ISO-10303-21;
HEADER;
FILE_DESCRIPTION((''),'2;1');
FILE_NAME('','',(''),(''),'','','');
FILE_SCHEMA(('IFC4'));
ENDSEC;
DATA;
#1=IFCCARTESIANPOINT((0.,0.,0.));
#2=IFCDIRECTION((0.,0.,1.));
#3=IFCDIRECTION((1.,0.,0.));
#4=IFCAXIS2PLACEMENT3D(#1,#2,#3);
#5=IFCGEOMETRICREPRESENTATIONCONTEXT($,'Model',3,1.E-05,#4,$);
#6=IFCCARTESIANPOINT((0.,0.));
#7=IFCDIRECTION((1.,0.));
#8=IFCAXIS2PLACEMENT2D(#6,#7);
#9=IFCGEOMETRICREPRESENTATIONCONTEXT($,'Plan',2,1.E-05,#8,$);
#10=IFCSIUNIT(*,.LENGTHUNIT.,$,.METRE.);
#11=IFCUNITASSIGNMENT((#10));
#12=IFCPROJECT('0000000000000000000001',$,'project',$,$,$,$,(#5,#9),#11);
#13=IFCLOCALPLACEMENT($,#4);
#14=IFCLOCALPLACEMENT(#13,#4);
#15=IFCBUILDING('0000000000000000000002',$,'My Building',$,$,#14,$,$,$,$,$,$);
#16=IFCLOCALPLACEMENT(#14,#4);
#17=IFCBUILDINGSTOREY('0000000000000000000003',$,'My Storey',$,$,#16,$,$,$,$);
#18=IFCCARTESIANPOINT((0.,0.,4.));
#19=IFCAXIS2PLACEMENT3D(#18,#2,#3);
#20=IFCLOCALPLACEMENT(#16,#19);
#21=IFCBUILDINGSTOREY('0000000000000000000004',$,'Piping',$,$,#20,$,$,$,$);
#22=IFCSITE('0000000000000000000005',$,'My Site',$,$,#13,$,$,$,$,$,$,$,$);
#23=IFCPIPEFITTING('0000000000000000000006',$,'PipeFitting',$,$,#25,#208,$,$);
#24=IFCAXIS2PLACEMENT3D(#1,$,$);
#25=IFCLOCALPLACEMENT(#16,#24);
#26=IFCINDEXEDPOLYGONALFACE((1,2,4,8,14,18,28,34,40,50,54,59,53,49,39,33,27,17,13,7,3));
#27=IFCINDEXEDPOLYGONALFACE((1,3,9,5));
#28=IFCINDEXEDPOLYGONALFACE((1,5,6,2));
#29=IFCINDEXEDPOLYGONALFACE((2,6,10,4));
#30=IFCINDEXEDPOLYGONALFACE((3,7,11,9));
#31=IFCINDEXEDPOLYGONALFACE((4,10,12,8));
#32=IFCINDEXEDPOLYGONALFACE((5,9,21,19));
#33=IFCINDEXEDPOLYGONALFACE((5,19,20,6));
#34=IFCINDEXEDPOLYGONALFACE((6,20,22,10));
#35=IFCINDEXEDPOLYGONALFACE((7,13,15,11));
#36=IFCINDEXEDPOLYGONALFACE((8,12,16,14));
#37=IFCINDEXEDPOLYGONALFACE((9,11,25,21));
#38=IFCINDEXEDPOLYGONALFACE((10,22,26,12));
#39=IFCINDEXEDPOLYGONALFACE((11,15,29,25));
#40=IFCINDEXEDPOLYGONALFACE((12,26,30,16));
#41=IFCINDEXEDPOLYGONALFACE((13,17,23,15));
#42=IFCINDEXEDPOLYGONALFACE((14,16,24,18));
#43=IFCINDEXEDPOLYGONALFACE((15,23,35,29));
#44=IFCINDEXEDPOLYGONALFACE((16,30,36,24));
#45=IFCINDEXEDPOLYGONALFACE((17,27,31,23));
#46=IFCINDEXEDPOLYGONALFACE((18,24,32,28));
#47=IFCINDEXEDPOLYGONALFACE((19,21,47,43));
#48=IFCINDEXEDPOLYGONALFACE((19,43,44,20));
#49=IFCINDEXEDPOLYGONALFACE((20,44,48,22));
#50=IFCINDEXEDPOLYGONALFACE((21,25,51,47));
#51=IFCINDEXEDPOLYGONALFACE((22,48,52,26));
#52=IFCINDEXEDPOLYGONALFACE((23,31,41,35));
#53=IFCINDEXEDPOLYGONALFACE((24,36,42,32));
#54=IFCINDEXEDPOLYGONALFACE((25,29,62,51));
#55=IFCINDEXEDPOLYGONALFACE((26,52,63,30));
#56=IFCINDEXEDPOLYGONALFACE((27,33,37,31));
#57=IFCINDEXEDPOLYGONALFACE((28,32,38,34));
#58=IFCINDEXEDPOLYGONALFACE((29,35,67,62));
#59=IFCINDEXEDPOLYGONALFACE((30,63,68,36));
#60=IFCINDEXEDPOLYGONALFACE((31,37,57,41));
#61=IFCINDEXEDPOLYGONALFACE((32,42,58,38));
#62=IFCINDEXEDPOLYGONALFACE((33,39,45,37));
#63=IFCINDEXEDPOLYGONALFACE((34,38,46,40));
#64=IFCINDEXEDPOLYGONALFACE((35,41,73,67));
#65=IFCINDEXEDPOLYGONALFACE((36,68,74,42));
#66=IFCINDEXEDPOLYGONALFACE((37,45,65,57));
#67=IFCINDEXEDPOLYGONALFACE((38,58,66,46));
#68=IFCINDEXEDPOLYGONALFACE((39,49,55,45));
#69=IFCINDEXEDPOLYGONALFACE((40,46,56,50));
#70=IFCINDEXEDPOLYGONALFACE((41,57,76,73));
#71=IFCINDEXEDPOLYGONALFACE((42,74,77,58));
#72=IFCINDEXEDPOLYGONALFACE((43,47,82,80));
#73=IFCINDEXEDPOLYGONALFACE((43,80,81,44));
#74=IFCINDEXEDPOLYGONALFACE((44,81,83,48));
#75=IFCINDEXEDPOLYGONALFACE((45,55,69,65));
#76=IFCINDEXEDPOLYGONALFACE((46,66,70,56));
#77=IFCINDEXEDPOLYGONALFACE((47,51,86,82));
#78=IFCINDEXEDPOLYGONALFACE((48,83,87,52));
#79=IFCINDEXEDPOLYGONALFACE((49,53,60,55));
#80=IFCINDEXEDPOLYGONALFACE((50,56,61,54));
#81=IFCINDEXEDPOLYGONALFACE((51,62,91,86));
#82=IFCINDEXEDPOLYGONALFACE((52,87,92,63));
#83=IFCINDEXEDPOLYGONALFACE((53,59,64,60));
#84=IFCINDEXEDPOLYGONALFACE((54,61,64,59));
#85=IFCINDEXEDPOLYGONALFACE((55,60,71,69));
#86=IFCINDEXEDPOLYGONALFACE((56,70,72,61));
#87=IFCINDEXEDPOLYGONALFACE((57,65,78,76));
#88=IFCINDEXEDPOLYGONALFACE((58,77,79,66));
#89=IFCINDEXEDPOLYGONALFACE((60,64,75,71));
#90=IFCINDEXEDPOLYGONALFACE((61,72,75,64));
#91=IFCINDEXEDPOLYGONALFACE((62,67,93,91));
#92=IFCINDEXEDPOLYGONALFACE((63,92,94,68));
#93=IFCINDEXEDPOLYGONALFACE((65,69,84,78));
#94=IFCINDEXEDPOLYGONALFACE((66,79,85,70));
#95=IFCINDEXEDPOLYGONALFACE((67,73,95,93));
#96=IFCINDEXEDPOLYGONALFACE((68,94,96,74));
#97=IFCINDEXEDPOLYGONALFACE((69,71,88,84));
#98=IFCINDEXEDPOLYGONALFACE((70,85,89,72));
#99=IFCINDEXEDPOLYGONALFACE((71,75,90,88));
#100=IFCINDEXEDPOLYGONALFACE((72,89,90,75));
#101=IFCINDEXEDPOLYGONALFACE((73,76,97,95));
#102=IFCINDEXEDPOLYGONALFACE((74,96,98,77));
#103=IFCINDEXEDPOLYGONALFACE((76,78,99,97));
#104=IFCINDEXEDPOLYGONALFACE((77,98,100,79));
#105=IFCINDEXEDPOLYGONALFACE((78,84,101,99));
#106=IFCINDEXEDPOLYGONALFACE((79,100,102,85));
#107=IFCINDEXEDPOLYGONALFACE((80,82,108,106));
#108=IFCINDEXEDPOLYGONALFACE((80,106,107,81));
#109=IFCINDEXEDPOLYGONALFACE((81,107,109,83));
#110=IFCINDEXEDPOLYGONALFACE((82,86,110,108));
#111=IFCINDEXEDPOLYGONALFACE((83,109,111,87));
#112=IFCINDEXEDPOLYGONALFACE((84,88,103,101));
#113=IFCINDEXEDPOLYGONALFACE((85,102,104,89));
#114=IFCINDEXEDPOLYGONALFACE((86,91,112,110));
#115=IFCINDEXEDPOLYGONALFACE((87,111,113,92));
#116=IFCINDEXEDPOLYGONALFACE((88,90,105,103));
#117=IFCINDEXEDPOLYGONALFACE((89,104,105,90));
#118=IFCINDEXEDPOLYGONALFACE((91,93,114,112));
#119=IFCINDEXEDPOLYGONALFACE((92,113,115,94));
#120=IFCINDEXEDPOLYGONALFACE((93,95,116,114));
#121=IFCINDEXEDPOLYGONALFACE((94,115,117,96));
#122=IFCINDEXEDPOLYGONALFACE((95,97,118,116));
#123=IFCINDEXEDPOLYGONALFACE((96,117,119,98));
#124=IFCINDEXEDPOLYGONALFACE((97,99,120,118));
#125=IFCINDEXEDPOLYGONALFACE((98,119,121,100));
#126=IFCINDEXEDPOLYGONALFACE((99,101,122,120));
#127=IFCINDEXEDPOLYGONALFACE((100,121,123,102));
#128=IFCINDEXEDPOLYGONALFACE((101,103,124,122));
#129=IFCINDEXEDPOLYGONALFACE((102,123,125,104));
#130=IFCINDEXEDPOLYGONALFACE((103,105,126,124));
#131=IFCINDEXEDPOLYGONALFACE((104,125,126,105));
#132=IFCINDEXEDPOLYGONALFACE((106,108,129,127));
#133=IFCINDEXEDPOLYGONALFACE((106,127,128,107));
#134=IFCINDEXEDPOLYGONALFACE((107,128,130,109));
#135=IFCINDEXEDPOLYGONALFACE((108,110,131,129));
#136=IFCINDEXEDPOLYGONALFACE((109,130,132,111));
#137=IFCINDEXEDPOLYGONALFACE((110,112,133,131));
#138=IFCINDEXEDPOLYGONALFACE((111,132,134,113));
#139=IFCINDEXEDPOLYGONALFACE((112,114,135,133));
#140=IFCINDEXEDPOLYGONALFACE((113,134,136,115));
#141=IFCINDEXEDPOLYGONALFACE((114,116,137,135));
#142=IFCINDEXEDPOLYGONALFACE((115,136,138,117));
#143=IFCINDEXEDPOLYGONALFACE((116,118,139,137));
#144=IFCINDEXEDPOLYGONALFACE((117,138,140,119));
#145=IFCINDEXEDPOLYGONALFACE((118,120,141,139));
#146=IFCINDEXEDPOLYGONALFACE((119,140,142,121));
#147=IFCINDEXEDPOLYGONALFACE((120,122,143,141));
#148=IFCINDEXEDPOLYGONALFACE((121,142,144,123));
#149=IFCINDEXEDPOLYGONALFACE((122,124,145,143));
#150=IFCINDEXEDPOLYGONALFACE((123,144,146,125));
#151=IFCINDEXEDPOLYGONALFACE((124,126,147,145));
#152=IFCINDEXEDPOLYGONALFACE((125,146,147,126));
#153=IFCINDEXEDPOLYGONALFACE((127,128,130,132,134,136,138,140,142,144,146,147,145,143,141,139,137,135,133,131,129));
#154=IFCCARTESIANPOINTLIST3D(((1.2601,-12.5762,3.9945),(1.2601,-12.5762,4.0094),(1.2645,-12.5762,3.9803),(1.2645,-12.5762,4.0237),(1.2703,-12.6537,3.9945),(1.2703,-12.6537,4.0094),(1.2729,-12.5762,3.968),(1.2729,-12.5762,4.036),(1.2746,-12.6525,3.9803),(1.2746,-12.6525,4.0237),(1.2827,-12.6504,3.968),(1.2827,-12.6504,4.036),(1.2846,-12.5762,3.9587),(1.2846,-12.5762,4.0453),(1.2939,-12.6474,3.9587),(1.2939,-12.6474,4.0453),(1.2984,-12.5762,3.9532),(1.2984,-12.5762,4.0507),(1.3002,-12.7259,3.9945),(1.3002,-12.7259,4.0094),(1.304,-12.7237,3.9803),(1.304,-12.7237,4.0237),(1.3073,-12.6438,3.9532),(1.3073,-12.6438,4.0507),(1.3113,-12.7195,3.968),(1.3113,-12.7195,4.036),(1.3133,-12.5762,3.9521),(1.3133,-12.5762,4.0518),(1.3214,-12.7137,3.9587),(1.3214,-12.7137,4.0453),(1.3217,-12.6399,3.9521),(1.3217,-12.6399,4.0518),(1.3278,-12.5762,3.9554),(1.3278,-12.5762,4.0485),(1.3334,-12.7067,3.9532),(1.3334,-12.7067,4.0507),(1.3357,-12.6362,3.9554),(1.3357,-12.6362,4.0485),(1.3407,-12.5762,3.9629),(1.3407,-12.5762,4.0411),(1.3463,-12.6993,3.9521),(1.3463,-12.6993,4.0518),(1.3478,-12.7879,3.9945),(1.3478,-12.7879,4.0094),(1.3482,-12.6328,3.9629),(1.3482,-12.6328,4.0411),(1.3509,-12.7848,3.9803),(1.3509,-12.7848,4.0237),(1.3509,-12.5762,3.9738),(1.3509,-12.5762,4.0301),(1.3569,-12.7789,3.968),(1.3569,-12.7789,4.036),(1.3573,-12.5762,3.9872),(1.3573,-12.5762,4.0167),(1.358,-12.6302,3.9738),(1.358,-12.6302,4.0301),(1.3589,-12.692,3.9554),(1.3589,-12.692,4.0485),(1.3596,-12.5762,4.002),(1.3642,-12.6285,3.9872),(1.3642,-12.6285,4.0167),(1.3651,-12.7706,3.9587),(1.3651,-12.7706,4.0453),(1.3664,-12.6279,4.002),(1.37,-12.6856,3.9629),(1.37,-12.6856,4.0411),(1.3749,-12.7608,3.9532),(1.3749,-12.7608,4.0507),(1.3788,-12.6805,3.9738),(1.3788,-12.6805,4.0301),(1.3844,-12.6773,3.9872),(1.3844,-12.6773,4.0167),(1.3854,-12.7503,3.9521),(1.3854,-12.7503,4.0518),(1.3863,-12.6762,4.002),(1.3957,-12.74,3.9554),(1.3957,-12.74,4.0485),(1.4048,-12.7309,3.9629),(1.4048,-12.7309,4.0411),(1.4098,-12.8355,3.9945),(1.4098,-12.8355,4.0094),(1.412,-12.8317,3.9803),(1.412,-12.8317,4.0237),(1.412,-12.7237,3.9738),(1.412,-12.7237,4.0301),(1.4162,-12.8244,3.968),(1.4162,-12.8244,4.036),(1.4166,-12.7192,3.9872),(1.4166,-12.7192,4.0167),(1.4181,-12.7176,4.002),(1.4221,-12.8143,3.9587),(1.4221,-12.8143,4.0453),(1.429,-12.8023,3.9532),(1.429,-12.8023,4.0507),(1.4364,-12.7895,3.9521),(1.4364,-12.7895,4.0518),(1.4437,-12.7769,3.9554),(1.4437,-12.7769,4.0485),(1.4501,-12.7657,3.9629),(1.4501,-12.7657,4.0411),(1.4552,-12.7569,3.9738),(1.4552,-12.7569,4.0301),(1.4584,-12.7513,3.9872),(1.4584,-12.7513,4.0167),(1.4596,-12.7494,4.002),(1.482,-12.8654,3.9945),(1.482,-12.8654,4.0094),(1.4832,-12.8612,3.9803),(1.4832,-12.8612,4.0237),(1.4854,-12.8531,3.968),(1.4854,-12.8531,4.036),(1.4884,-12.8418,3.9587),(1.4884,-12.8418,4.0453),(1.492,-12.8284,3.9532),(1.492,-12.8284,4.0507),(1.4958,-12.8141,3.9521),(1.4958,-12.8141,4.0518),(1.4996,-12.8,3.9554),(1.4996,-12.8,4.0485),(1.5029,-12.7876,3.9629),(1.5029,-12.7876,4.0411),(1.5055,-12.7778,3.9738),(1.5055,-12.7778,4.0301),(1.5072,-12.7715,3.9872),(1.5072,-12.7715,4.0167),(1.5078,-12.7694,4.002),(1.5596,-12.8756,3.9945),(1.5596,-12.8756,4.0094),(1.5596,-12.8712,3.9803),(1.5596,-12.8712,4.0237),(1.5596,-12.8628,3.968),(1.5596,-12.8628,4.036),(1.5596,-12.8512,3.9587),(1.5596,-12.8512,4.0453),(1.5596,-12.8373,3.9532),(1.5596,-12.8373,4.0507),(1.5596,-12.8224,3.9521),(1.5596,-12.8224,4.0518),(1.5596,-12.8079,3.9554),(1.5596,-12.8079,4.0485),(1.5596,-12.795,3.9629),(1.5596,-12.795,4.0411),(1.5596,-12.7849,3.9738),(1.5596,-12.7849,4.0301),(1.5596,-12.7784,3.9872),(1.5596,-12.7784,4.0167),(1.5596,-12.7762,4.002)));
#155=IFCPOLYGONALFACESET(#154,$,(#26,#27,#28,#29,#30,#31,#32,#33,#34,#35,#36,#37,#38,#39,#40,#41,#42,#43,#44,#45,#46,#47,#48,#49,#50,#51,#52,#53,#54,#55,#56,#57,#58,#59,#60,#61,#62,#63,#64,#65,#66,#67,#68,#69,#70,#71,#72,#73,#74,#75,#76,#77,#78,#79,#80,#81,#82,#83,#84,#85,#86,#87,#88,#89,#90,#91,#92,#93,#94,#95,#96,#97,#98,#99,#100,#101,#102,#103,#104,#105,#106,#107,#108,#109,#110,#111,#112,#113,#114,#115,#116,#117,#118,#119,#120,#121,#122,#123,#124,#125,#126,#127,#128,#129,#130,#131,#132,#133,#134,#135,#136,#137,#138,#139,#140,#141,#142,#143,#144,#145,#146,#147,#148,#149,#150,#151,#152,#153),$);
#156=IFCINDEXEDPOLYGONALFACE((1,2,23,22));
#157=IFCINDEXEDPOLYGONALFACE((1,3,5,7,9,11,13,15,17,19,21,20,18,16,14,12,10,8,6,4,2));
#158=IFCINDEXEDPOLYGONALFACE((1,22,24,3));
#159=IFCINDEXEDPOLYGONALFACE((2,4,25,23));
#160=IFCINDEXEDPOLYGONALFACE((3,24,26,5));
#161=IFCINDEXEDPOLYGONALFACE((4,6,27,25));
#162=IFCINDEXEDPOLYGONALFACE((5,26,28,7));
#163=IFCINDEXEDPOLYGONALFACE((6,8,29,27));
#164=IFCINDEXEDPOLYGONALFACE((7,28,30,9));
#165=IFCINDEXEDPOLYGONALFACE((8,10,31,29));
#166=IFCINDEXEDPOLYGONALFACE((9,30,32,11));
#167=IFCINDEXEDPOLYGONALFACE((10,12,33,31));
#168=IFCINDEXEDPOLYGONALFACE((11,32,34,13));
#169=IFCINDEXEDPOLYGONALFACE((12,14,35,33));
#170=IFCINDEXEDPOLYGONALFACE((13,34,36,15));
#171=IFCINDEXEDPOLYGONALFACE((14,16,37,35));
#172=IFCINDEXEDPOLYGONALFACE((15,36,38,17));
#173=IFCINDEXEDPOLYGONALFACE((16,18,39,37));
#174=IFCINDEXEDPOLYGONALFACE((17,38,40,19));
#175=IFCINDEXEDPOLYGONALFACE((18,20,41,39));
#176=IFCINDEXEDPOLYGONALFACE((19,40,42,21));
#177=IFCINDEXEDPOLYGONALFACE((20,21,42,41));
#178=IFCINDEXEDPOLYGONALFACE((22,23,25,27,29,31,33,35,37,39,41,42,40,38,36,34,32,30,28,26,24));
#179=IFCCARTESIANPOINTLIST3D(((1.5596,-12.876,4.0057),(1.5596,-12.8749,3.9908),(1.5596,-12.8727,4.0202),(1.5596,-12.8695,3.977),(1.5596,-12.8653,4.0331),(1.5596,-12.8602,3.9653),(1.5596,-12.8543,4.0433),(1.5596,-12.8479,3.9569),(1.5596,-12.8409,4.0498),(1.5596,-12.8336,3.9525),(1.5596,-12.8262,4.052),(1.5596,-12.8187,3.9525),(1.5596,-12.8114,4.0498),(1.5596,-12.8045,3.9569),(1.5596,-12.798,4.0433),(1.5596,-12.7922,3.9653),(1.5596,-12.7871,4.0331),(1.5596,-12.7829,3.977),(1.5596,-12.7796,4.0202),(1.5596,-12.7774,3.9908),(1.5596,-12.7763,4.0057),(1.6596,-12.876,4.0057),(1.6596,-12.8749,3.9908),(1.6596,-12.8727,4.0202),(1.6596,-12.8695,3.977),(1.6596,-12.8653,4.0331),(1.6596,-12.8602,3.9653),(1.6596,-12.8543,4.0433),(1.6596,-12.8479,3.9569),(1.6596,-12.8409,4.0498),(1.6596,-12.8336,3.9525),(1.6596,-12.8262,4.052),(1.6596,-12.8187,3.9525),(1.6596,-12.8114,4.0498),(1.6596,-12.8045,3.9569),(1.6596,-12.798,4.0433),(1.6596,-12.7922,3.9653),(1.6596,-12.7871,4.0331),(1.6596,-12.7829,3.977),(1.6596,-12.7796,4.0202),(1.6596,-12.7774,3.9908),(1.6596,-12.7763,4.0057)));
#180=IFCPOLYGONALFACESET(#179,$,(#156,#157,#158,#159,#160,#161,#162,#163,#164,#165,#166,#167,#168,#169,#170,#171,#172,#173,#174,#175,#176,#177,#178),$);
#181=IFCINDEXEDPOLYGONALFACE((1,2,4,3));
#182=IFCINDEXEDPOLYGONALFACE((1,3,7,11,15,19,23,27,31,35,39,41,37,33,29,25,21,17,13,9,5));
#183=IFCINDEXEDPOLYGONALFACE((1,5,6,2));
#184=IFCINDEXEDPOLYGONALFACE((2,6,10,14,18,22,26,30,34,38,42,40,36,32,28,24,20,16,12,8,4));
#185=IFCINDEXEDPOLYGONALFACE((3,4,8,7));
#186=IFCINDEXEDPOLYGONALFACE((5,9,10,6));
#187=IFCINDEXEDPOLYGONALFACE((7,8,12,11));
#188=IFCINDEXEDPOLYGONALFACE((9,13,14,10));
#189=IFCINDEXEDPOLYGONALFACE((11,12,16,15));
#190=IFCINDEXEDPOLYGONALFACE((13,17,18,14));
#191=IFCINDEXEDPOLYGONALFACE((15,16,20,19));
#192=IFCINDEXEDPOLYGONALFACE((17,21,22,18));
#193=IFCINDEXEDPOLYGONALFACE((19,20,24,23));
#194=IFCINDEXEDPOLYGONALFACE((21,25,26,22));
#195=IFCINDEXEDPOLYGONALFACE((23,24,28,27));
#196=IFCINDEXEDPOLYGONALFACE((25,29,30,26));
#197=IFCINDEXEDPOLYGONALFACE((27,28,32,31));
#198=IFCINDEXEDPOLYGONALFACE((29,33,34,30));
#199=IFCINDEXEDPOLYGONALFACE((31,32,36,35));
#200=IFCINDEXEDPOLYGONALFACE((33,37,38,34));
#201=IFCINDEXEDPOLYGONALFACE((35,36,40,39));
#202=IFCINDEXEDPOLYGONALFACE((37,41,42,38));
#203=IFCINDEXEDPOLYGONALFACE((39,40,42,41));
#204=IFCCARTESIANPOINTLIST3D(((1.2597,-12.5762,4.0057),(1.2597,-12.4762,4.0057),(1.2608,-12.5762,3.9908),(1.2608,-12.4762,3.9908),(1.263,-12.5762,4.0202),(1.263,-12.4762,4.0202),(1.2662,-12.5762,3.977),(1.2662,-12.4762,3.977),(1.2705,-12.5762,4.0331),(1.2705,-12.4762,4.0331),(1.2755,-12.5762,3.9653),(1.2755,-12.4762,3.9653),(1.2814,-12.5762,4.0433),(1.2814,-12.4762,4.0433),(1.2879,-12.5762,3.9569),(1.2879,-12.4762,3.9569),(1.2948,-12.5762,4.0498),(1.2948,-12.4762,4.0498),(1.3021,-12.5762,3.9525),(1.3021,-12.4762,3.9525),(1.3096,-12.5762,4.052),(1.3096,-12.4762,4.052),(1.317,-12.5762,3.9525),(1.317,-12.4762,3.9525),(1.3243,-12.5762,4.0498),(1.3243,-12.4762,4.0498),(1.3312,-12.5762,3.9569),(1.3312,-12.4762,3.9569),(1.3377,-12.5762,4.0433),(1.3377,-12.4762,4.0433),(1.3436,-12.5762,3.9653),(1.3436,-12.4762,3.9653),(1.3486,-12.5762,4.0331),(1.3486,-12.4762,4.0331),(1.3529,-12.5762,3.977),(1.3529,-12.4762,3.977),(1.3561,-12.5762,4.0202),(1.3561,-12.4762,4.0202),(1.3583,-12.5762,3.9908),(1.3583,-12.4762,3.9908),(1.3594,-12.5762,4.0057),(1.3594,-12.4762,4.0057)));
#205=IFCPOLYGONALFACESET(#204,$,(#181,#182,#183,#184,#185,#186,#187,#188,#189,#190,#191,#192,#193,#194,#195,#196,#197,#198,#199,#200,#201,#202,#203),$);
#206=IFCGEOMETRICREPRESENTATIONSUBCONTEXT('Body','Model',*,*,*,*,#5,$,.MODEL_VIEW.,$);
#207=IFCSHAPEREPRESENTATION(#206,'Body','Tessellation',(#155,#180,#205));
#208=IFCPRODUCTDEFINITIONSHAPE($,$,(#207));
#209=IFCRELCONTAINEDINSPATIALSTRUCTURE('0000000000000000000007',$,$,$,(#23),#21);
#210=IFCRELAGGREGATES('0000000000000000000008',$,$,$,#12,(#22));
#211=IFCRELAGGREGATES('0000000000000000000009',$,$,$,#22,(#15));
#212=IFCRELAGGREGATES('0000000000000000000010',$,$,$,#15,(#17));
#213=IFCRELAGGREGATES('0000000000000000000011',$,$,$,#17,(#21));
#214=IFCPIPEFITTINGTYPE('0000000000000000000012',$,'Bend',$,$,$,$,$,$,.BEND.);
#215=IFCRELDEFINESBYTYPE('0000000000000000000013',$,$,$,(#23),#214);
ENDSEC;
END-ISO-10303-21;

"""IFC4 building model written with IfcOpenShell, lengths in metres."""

from ifc_helpers import new_model, entity, si_unit, frame, origin_with_axes, origin_2d_with_axis, place, context, subcontext, project, spatial, circle, extrude, source, transform, mapped, type_object, type_shapes, element, save


model = new_model("IFC4")

# Units and contexts
model_context = context("Model", 3, precision=1e-05, world=origin_with_axes())
plan_context = context("Plan", 2, precision=1e-05, world=origin_2d_with_axis())
body_context = subcontext(model_context, "Body", "Model", "MODEL_VIEW")
ifc_project = project(units=[si_unit("LENGTHUNIT", "METRE")], contexts=[model_context, plan_context])

# Site, building, storeys
site_placement = place(None, origin_with_axes())
site = spatial("IfcSite", under=ifc_project, at=site_placement, Name="My Site")
building_placement = place(site_placement, origin_with_axes())
building = spatial("IfcBuilding", under=site, at=building_placement, Name="My Building")
storey_1_placement = place(building_placement, origin_with_axes())
storey_1 = spatial("IfcBuildingStorey", under=building, at=storey_1_placement, Name="My Storey")
storey_2_placement = place(storey_1_placement, frame((0.0, 0.0, 4.0), z_axis=(0.0, 0.0, 1.0), x_axis=(1.0, 0.0, 0.0)))
storey_2 = spatial("IfcBuildingStorey", under=storey_1, at=storey_2_placement, Name="Piping")

# Shared definitions
pipe_fitting_type_1 = type_object("IfcPipeFittingType", Name="Bend", PredefinedType="BEND")
shared_shape = source(origin_with_axes(), body_context, "Body", "SolidModel", [
    entity("IfcSweptDiskSolid", entity("IfcIndexedPolyCurve", entity("IfcCartesianPointList3D", [[0.0, 0.0, -0.1], [0.0, -0.0732, -0.2768], [0.0, -0.25, -0.35]]), [entity("IfcArcIndex", [1, 2, 3])]), 0.05),
    extrude(circle(Radius=0.05), origin_with_axes(), (0.0, 0.0, -1.0), 0.1),
    extrude(circle(Radius=0.05), frame((0.0, -0.25, -0.35), z_axis=(0.0, -1.0, 0.0), x_axis=(1.0, 0.0, 0.0)), (0.0, 0.0, 1.0), 0.1),
])
type_shapes(pipe_fitting_type_1, [shared_shape])

# Pipe fitting
for number, where, z_axis, x_axis, name in (
    (1, (1.6596, -12.8262, 0.002), (1.0, 0.0, 0.0), (0.0, 0.0, 1.0), "PipeFitting"),
):
    element("IfcPipeFitting", number, at=place(storey_2_placement, frame(where, z_axis=z_axis, x_axis=x_axis)), inside=storey_2, type_object=pipe_fitting_type_1, Name=name, context=body_context, shape_type="MappedRepresentation", body=[
        mapped(shared_shape, transform((0.0, 0.0, 0.0), x_axis=(1.0, 0.0, 0.0), y_axis=(0.0, 1.0, 0.0), z_axis=(0.0, 0.0, 1.0), scale=1.0)),
    ])

save(model, "model.ifc")
